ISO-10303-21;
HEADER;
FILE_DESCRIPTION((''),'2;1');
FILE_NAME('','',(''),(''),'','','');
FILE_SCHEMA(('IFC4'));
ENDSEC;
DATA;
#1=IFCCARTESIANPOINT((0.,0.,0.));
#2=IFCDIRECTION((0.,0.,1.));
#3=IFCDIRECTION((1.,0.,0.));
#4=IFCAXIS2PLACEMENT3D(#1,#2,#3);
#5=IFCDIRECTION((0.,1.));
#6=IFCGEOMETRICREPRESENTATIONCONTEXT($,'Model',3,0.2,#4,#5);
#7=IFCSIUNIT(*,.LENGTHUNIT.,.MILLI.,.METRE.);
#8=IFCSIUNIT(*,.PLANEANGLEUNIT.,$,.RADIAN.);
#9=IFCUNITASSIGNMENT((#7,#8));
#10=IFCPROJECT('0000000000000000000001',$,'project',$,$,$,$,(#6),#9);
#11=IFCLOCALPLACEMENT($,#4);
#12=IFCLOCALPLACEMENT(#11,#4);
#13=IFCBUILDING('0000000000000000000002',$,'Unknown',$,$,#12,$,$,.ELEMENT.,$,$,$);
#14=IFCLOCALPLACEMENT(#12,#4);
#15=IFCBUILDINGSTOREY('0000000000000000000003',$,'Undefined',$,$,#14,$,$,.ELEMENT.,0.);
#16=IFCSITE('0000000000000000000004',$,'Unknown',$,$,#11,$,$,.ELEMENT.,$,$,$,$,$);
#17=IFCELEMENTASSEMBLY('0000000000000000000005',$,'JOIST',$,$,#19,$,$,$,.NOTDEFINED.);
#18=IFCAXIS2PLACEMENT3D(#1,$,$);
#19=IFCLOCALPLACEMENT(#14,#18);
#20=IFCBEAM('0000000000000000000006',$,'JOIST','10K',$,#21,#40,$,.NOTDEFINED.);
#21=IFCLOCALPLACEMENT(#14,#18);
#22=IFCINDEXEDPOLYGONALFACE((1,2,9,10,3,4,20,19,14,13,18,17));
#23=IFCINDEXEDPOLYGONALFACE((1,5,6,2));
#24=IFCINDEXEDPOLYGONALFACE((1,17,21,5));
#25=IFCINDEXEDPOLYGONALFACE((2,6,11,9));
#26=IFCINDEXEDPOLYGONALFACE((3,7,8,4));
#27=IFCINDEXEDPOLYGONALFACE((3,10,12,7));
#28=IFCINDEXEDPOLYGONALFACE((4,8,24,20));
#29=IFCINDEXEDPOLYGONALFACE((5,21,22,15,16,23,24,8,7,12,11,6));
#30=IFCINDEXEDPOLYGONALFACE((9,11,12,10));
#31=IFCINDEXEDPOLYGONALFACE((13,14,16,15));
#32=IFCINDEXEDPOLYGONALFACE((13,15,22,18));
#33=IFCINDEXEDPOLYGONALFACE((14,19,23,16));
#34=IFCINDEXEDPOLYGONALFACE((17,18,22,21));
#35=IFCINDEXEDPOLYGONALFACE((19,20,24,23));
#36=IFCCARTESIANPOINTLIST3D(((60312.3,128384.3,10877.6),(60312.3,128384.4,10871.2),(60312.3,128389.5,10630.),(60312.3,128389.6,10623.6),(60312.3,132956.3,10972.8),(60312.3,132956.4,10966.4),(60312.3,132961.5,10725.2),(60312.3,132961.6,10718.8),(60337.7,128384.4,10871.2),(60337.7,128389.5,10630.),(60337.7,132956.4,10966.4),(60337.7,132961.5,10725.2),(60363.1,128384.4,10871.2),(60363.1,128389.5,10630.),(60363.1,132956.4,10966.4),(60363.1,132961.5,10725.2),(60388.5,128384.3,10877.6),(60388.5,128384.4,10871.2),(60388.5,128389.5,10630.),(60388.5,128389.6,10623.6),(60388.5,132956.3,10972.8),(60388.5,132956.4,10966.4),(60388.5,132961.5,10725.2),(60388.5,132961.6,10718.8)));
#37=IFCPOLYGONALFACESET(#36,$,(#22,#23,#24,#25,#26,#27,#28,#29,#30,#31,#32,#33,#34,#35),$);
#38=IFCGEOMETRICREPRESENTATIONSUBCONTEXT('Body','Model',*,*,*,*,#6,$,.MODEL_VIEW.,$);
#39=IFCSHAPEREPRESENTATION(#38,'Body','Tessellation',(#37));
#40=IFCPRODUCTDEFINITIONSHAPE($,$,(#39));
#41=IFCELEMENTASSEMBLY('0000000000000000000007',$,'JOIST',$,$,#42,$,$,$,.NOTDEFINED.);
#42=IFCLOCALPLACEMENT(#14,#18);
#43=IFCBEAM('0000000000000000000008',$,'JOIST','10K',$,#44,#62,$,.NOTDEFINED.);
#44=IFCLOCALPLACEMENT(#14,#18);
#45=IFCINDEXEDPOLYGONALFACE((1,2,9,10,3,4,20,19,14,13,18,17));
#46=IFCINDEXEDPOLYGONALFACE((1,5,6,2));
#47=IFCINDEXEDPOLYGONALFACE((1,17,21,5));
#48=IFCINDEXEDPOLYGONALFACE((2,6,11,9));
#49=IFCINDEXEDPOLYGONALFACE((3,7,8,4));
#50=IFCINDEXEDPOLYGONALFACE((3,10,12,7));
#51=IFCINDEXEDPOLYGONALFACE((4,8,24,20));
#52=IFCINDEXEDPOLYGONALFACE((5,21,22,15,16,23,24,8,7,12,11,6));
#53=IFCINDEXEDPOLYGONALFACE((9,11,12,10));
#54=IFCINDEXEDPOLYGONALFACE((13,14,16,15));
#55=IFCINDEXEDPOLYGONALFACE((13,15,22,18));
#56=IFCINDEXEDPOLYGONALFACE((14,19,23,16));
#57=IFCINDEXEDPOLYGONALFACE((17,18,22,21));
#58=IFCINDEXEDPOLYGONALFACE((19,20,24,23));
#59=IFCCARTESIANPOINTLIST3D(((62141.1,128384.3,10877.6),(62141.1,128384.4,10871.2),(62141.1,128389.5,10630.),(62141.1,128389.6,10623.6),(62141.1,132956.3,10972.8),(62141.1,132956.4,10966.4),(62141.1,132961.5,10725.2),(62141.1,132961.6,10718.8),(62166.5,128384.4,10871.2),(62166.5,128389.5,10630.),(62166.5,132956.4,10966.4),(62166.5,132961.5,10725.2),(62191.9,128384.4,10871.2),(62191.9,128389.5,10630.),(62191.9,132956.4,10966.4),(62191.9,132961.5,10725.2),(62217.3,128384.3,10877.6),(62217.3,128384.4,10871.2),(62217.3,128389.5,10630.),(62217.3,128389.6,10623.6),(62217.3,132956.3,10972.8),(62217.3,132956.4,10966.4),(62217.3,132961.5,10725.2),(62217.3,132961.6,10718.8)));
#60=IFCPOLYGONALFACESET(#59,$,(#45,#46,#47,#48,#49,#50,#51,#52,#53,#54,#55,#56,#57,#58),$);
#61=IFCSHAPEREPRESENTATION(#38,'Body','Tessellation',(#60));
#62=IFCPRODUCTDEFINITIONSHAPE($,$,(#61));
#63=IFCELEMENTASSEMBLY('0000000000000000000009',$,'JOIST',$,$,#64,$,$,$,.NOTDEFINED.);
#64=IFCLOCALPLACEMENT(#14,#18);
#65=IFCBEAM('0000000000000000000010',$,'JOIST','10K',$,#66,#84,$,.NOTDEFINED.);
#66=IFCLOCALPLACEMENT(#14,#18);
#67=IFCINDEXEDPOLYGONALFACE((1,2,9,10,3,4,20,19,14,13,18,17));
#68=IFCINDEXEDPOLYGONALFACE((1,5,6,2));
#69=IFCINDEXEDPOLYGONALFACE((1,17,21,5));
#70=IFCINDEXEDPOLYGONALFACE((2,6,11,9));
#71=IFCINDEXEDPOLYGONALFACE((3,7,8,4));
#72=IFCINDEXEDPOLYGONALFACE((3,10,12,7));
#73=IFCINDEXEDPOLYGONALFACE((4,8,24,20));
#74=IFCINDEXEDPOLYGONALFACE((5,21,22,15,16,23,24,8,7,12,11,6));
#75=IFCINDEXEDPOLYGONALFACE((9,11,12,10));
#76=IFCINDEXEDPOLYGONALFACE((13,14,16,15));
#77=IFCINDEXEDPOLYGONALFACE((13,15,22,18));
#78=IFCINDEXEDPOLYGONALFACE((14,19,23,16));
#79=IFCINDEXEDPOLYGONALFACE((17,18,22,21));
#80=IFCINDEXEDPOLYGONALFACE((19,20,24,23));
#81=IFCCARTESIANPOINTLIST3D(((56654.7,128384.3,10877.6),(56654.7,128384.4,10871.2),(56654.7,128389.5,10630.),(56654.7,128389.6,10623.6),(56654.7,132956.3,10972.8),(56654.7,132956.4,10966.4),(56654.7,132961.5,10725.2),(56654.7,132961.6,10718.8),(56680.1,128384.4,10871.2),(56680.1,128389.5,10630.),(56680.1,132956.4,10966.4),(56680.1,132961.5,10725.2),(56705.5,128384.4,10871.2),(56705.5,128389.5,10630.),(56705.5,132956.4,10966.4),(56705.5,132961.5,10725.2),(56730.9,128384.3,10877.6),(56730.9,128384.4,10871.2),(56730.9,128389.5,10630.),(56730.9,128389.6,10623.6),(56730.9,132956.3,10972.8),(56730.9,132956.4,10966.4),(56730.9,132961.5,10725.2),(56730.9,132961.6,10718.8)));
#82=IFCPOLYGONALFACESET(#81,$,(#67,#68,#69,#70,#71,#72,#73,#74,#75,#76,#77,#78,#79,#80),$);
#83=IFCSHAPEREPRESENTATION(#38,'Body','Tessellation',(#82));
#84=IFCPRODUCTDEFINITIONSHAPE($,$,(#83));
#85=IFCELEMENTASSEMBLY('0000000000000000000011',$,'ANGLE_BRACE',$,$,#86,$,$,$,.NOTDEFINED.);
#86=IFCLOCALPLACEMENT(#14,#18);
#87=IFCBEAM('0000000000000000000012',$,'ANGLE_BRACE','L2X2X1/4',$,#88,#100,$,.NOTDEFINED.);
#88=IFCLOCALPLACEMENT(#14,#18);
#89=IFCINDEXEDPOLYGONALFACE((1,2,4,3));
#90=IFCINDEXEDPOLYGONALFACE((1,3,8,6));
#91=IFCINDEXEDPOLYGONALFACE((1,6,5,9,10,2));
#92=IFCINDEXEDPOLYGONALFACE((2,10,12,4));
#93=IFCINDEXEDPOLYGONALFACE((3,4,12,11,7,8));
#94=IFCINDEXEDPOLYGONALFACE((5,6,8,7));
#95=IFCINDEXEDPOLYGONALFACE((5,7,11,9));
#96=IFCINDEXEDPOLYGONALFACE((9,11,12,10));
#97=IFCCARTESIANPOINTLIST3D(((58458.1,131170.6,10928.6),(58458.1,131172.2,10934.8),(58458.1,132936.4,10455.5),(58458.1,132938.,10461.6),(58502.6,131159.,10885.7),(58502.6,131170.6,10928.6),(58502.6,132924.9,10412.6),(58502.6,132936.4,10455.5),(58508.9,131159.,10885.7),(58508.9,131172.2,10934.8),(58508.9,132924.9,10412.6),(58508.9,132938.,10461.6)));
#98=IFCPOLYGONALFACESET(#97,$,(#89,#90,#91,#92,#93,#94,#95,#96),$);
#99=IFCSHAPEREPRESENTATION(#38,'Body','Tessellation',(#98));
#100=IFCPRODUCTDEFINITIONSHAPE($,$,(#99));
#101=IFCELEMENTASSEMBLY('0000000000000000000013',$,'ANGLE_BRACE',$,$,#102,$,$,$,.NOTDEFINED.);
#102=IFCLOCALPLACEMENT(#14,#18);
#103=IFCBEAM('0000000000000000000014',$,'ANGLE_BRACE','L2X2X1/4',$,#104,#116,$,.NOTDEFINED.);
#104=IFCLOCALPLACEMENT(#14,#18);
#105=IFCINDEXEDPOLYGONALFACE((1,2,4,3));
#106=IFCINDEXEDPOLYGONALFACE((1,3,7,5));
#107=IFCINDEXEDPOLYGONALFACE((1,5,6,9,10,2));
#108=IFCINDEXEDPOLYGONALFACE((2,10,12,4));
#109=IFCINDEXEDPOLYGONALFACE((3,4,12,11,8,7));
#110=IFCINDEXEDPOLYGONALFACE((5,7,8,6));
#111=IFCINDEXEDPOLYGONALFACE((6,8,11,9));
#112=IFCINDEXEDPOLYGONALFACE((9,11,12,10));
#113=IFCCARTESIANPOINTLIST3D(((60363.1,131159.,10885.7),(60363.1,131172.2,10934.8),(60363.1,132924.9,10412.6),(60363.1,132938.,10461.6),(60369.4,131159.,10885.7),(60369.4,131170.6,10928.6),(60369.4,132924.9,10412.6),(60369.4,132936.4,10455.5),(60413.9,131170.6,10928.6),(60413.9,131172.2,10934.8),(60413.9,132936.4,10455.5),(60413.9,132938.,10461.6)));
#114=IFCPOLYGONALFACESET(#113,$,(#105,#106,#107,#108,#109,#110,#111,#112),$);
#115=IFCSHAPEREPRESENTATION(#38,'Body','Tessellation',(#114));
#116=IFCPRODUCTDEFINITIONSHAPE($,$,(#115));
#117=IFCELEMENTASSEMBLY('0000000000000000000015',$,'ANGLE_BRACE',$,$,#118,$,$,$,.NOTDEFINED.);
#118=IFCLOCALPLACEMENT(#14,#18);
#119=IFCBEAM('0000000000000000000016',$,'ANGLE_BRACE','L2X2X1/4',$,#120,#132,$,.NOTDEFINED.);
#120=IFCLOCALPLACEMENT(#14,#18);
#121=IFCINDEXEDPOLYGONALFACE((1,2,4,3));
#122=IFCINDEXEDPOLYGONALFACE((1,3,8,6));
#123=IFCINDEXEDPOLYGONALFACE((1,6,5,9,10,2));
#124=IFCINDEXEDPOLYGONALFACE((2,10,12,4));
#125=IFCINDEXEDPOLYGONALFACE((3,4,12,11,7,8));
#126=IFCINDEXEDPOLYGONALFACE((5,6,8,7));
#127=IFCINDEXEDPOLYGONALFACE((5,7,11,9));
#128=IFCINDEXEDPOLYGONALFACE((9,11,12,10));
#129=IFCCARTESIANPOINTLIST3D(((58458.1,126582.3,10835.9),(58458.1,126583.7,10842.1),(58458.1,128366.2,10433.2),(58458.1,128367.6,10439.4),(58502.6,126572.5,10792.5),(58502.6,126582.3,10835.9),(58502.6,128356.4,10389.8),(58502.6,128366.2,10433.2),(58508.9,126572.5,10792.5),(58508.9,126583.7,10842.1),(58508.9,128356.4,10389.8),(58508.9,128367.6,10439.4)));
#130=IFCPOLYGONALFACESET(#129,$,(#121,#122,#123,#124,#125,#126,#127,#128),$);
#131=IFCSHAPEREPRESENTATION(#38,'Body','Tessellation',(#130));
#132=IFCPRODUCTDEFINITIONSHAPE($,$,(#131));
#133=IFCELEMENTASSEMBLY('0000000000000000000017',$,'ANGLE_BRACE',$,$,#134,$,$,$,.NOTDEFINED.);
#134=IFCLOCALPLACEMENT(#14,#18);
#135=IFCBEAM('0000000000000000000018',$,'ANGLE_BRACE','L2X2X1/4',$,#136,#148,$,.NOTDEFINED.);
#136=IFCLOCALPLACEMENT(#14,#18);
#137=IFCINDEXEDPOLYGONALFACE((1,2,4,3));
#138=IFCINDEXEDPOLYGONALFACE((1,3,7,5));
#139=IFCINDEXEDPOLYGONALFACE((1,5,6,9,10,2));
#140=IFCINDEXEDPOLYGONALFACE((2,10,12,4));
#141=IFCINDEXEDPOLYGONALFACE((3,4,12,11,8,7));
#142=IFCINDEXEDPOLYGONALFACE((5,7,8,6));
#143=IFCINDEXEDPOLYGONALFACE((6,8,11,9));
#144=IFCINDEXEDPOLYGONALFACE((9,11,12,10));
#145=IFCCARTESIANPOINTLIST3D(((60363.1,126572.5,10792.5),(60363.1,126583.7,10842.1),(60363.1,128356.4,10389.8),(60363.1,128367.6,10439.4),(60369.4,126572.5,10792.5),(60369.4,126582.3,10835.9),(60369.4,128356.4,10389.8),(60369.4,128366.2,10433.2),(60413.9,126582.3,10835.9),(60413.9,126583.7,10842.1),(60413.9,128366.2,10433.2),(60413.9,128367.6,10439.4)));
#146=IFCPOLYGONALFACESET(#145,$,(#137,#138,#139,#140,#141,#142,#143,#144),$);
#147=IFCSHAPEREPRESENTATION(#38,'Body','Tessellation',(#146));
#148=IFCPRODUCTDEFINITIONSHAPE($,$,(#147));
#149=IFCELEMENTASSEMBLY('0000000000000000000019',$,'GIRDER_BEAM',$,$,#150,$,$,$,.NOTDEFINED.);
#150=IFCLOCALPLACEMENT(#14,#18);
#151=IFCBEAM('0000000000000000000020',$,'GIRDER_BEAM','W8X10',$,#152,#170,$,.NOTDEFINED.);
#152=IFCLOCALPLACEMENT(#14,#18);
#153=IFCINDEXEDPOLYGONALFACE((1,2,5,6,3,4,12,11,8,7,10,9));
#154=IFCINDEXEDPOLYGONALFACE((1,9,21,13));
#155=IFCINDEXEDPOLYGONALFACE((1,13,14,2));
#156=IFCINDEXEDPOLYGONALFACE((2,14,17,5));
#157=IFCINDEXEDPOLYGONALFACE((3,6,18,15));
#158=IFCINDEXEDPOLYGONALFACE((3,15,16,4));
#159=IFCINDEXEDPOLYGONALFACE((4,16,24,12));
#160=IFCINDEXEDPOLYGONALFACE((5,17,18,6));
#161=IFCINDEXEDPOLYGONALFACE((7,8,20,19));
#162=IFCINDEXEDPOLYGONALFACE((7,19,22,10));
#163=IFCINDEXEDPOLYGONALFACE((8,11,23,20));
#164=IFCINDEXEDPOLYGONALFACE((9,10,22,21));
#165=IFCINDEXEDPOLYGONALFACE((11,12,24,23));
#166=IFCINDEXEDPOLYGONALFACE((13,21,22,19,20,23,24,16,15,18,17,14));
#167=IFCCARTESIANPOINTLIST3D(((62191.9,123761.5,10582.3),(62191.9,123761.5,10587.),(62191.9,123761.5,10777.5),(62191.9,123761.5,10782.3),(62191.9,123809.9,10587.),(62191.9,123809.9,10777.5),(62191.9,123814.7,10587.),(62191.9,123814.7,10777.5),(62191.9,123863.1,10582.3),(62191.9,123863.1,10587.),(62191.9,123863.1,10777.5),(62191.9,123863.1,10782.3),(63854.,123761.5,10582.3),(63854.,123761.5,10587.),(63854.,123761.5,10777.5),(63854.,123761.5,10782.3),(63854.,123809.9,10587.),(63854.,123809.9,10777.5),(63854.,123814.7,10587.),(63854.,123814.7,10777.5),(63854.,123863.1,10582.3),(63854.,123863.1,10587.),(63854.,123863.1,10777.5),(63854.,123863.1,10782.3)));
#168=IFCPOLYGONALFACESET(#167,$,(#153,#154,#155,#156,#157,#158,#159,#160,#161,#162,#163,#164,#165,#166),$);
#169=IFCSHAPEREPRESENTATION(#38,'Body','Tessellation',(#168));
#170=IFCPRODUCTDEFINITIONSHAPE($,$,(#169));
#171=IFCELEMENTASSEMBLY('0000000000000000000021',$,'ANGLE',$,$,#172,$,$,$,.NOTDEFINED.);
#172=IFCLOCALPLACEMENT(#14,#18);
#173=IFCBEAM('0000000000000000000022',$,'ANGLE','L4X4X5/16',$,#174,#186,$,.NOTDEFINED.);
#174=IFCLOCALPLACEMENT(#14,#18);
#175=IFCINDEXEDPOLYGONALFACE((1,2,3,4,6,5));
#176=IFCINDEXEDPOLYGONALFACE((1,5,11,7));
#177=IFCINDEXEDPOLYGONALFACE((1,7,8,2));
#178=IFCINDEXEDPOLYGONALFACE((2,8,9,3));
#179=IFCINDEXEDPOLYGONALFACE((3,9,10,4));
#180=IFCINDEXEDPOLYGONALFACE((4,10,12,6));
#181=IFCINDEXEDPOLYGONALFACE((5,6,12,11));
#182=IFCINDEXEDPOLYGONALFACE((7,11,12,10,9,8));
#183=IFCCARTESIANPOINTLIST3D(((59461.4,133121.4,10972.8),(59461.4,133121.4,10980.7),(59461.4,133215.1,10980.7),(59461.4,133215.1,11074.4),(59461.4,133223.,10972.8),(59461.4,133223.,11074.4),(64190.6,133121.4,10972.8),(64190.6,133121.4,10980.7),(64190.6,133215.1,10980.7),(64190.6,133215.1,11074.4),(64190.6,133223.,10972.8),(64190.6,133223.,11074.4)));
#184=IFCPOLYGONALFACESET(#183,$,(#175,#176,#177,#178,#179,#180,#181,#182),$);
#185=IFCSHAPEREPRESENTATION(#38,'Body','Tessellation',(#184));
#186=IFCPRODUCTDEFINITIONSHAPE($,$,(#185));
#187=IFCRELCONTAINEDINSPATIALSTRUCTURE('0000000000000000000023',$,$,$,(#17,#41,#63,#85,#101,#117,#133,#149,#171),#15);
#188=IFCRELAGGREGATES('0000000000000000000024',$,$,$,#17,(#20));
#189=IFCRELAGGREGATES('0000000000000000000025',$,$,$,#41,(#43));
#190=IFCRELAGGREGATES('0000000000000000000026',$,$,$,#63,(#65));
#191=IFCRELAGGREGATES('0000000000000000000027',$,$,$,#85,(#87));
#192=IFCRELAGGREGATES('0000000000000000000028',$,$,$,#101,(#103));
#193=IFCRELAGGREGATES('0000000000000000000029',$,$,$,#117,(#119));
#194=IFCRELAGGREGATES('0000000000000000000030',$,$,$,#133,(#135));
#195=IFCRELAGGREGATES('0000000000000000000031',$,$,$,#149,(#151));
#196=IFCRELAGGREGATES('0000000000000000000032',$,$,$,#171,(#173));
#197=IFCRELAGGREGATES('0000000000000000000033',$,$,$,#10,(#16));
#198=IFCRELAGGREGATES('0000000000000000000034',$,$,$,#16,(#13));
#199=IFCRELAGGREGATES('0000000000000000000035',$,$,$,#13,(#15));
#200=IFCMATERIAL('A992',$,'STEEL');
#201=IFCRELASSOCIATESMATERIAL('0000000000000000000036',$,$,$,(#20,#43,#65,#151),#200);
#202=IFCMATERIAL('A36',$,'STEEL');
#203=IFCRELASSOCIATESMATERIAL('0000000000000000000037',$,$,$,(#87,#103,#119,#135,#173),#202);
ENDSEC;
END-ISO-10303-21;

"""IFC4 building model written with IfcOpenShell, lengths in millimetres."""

from ifc_helpers import new_model, si_unit, direction, frame, origin_with_axes, place, context, subcontext, project, spatial, line, indexed_curve, outline, extrude, material, element, aggregate, save


model = new_model("IFC4")

# Units and contexts
model_context = context("Model", 3, precision=0.2, world=origin_with_axes(), true_north=direction((0.0, 1.0)))
body_context = subcontext(model_context, "Body", "Model", "MODEL_VIEW")
ifc_project = project(units=[si_unit("LENGTHUNIT", "METRE", prefix="MILLI"), si_unit("PLANEANGLEUNIT", "RADIAN")], contexts=[model_context])

# Site, building, storey
site_placement = place(None, origin_with_axes())
site = spatial("IfcSite", under=ifc_project, at=site_placement, Name="Unknown", CompositionType="ELEMENT")
building_placement = place(site_placement, origin_with_axes())
building = spatial("IfcBuilding", under=site, at=building_placement, Name="Unknown", CompositionType="ELEMENT")
storey_placement = place(building_placement, origin_with_axes())
storey = spatial("IfcBuildingStorey", under=building, at=storey_placement, Name="Undefined", CompositionType="ELEMENT", Elevation=0.0)

# Shared definitions
ifc_material_1 = material(Name="A992", Category="STEEL")

# Element assemblies, beams
ifc_material_2 = material(Name="A36", Category="STEEL")
assembly_1_placement = place(storey_placement, frame((60350.4, 128386.9, 10750.6), z_axis=(1.0, 0.0, 0.0), x_axis=(0.0, 0.999783, 0.020819)))
assembly_1 = element("IfcElementAssembly", 1, at=assembly_1_placement, inside=storey, Name="JOIST", PredefinedType="NOTDEFINED")
beam_1_placement = place(assembly_1_placement, origin_with_axes())
beam_1 = element("IfcBeam", 2, at=beam_1_placement, material=ifc_material_1, Name="JOIST", Description="10K", PredefinedType="NOTDEFINED", context=body_context, shape_type="SolidModel", body=[
    extrude(outline(indexed_curve([(-38.1, -127.0), (38.1, -127.0), (38.1, -120.7), (12.7, -120.7), (12.7, 120.7), (38.1, 120.7), (38.1, 127.0), (-38.1, 127.0), (-38.1, 120.7), (-12.7, 120.7), (-12.7, -120.7), (-38.1, -120.7)], segments=[line(1, 2, 3, 4, 5, 6, 7, 8, 9, 10, 11, 12, 1)])), frame((0.0, 0.0, 0.0), z_axis=(-1.0, 0.0, 0.0), x_axis=(0.0, 0.0, 1.0)), (0.0, 0.0, -1.0), 4573.0),
])
aggregate(assembly_1, [beam_1])
assembly_2_placement = place(storey_placement, frame((62179.2, 128386.9, 10750.6), z_axis=(1.0, 0.0, 0.0), x_axis=(0.0, 0.999783, 0.020819)))
assembly_2 = element("IfcElementAssembly", 3, at=assembly_2_placement, inside=storey, Name="JOIST", PredefinedType="NOTDEFINED")
beam_2_placement = place(assembly_2_placement, origin_with_axes())
beam_2 = element("IfcBeam", 4, at=beam_2_placement, material=ifc_material_1, Name="JOIST", Description="10K", PredefinedType="NOTDEFINED", context=body_context, shape_type="SolidModel", body=[
    extrude(outline(indexed_curve([(-38.1, -127.0), (38.1, -127.0), (38.1, -120.7), (12.7, -120.7), (12.7, 120.7), (38.1, 120.7), (38.1, 127.0), (-38.1, 127.0), (-38.1, 120.7), (-12.7, 120.7), (-12.7, -120.7), (-38.1, -120.7)], segments=[line(1, 2, 3, 4, 5, 6, 7, 8, 9, 10, 11, 12, 1)])), frame((0.0, 0.0, 0.0), z_axis=(-1.0, 0.0, 0.0), x_axis=(0.0, 0.0, 1.0)), (0.0, 0.0, -1.0), 4573.0),
])
aggregate(assembly_2, [beam_2])
assembly_3_placement = place(storey_placement, frame((56692.8, 128386.9, 10750.6), z_axis=(1.0, 0.0, 0.0), x_axis=(0.0, 0.999783, 0.020819)))
assembly_3 = element("IfcElementAssembly", 5, at=assembly_3_placement, inside=storey, Name="JOIST", PredefinedType="NOTDEFINED")
beam_3_placement = place(assembly_3_placement, origin_with_axes())
beam_3 = element("IfcBeam", 6, at=beam_3_placement, material=ifc_material_1, Name="JOIST", Description="10K", PredefinedType="NOTDEFINED", context=body_context, shape_type="SolidModel", body=[
    extrude(outline(indexed_curve([(-38.1, -127.0), (38.1, -127.0), (38.1, -120.7), (12.7, -120.7), (12.7, 120.7), (38.1, 120.7), (38.1, 127.0), (-38.1, 127.0), (-38.1, 120.7), (-12.7, 120.7), (-12.7, -120.7), (-38.1, -120.7)], segments=[line(1, 2, 3, 4, 5, 6, 7, 8, 9, 10, 11, 12, 1)])), frame((0.0, 0.0, 0.0), z_axis=(-1.0, 0.0, 0.0), x_axis=(0.0, 0.0, 1.0)), (0.0, 0.0, -1.0), 4573.0),
])
aggregate(assembly_3, [beam_3])
assembly_4_placement = place(storey_placement, frame((58483.5, 131165.6, 10910.2), z_axis=(-1.0, 0.0, 0.0), x_axis=(0.0, 0.965926, -0.258819)))
assembly_4 = element("IfcElementAssembly", 7, at=assembly_4_placement, inside=storey, Name="ANGLE_BRACE", PredefinedType="NOTDEFINED")
beam_4_placement = place(assembly_4_placement, origin_with_axes())
beam_4 = element("IfcBeam", 8, at=beam_4_placement, material=ifc_material_2, Name="ANGLE_BRACE", Description="L2X2X1/4", PredefinedType="NOTDEFINED", context=body_context, shape_type="SolidModel", body=[
    extrude(outline(indexed_curve([(-25.4, -25.4), (25.4, -25.4), (25.4, -19.1), (-19.1, -19.1), (-19.1, 25.4), (-25.4, 25.4)], segments=[line(1, 2, 3, 4, 5, 6, 1)])), frame((0.0, 0.0, 0.0), z_axis=(-1.0, 0.0, 0.0), x_axis=(0.0, 0.0, 1.0)), (0.0, 0.0, -1.0), 1828.1),
])
aggregate(assembly_4, [beam_4])
assembly_5_placement = place(storey_placement, frame((60388.5, 131165.6, 10910.2), z_axis=(0.0, -0.258819, -0.965926), x_axis=(0.0, 0.965926, -0.258819)))
assembly_5 = element("IfcElementAssembly", 9, at=assembly_5_placement, inside=storey, Name="ANGLE_BRACE", PredefinedType="NOTDEFINED")
beam_5_placement = place(assembly_5_placement, origin_with_axes())
beam_5 = element("IfcBeam", 10, at=beam_5_placement, material=ifc_material_2, Name="ANGLE_BRACE", Description="L2X2X1/4", PredefinedType="NOTDEFINED", context=body_context, shape_type="SolidModel", body=[
    extrude(outline(indexed_curve([(-25.4, -25.4), (25.4, -25.4), (25.4, -19.1), (-19.1, -19.1), (-19.1, 25.4), (-25.4, 25.4)], segments=[line(1, 2, 3, 4, 5, 6, 1)])), frame((0.0, 0.0, 0.0), z_axis=(-1.0, 0.0, 0.0), x_axis=(0.0, 0.0, 1.0)), (0.0, 0.0, -1.0), 1828.1),
])
aggregate(assembly_5, [beam_5])
assembly_6_placement = place(storey_placement, frame((58483.5, 126578.1, 10817.3), z_axis=(-1.0, 0.0, 0.0), x_axis=(0.0, 0.97546, -0.220178)))
assembly_6 = element("IfcElementAssembly", 11, at=assembly_6_placement, inside=storey, Name="ANGLE_BRACE", PredefinedType="NOTDEFINED")
beam_6_placement = place(assembly_6_placement, origin_with_axes())
beam_6 = element("IfcBeam", 12, at=beam_6_placement, material=ifc_material_2, Name="ANGLE_BRACE", Description="L2X2X1/4", PredefinedType="NOTDEFINED", context=body_context, shape_type="SolidModel", body=[
    extrude(outline(indexed_curve([(-25.4, -25.4), (25.4, -25.4), (25.4, -19.1), (-19.1, -19.1), (-19.1, 25.4), (-25.4, 25.4)], segments=[line(1, 2, 3, 4, 5, 6, 1)])), frame((0.0, 0.0, 0.0), z_axis=(-1.0, 0.0, 0.0), x_axis=(0.0, 0.0, 1.0)), (0.0, 0.0, -1.0), 1828.8),
])
aggregate(assembly_6, [beam_6])
assembly_7_placement = place(storey_placement, frame((60388.5, 126578.1, 10817.3), z_axis=(0.0, -0.220178, -0.97546), x_axis=(0.0, 0.97546, -0.220178)))
assembly_7 = element("IfcElementAssembly", 13, at=assembly_7_placement, inside=storey, Name="ANGLE_BRACE", PredefinedType="NOTDEFINED")
beam_7_placement = place(assembly_7_placement, origin_with_axes())
beam_7 = element("IfcBeam", 14, at=beam_7_placement, material=ifc_material_2, Name="ANGLE_BRACE", Description="L2X2X1/4", PredefinedType="NOTDEFINED", context=body_context, shape_type="SolidModel", body=[
    extrude(outline(indexed_curve([(-25.4, -25.4), (25.4, -25.4), (25.4, -19.1), (-19.1, -19.1), (-19.1, 25.4), (-25.4, 25.4)], segments=[line(1, 2, 3, 4, 5, 6, 1)])), frame((0.0, 0.0, 0.0), z_axis=(-1.0, 0.0, 0.0), x_axis=(0.0, 0.0, 1.0)), (0.0, 0.0, -1.0), 1828.8),
])
aggregate(assembly_7, [beam_7])
assembly_8_placement = place(storey_placement, frame((62191.9, 123812.3, 10682.3), z_axis=(0.0, -1.0, 0.0), x_axis=(1.0, 0.0, 0.0)))
assembly_8 = element("IfcElementAssembly", 15, at=assembly_8_placement, inside=storey, Name="GIRDER_BEAM", PredefinedType="NOTDEFINED")
beam_8_placement = place(assembly_8_placement, origin_with_axes())
beam_8 = element("IfcBeam", 16, at=beam_8_placement, material=ifc_material_1, Name="GIRDER_BEAM", Description="W8X10", PredefinedType="NOTDEFINED", context=body_context, shape_type="SolidModel", body=[
    extrude(outline(indexed_curve([(-50.8, -100.0), (50.8, -100.0), (50.8, -95.2), (2.4, -95.2), (2.4, 95.2), (50.8, 95.2), (50.8, 100.0), (-50.8, 100.0), (-50.8, 95.2), (-2.4, 95.2), (-2.4, -95.2), (-50.8, -95.2)], segments=[line(1, 2, 3, 4, 5, 6, 7, 8, 9, 10, 11, 12, 1)])), frame((0.0, 0.0, 0.0), z_axis=(-1.0, 0.0, 0.0), x_axis=(0.0, 0.0, 1.0)), (0.0, 0.0, -1.0), 1662.1),
])
aggregate(assembly_8, [beam_8])
assembly_9_placement = place(storey_placement, frame((59461.4, 133172.2, 11023.6), z_axis=(0.0, -1.0, 0.0), x_axis=(1.0, 0.0, 0.0)))
assembly_9 = element("IfcElementAssembly", 17, at=assembly_9_placement, inside=storey, Name="ANGLE", PredefinedType="NOTDEFINED")
beam_9_placement = place(assembly_9_placement, origin_with_axes())
beam_9 = element("IfcBeam", 18, at=beam_9_placement, material=ifc_material_2, Name="ANGLE", Description="L4X4X5/16", PredefinedType="NOTDEFINED", context=body_context, shape_type="SolidModel", body=[
    extrude(outline(indexed_curve([(-50.8, -50.8), (50.8, -50.8), (50.8, -42.9), (-42.9, -42.9), (-42.9, 50.8), (-50.8, 50.8)], segments=[line(1, 2, 3, 4, 5, 6, 1)])), frame((0.0, 0.0, 0.0), z_axis=(-1.0, 0.0, 0.0), x_axis=(0.0, 0.0, 1.0)), (0.0, 0.0, -1.0), 4729.2),
])
aggregate(assembly_9, [beam_9])

save(model, "model.ifc")
